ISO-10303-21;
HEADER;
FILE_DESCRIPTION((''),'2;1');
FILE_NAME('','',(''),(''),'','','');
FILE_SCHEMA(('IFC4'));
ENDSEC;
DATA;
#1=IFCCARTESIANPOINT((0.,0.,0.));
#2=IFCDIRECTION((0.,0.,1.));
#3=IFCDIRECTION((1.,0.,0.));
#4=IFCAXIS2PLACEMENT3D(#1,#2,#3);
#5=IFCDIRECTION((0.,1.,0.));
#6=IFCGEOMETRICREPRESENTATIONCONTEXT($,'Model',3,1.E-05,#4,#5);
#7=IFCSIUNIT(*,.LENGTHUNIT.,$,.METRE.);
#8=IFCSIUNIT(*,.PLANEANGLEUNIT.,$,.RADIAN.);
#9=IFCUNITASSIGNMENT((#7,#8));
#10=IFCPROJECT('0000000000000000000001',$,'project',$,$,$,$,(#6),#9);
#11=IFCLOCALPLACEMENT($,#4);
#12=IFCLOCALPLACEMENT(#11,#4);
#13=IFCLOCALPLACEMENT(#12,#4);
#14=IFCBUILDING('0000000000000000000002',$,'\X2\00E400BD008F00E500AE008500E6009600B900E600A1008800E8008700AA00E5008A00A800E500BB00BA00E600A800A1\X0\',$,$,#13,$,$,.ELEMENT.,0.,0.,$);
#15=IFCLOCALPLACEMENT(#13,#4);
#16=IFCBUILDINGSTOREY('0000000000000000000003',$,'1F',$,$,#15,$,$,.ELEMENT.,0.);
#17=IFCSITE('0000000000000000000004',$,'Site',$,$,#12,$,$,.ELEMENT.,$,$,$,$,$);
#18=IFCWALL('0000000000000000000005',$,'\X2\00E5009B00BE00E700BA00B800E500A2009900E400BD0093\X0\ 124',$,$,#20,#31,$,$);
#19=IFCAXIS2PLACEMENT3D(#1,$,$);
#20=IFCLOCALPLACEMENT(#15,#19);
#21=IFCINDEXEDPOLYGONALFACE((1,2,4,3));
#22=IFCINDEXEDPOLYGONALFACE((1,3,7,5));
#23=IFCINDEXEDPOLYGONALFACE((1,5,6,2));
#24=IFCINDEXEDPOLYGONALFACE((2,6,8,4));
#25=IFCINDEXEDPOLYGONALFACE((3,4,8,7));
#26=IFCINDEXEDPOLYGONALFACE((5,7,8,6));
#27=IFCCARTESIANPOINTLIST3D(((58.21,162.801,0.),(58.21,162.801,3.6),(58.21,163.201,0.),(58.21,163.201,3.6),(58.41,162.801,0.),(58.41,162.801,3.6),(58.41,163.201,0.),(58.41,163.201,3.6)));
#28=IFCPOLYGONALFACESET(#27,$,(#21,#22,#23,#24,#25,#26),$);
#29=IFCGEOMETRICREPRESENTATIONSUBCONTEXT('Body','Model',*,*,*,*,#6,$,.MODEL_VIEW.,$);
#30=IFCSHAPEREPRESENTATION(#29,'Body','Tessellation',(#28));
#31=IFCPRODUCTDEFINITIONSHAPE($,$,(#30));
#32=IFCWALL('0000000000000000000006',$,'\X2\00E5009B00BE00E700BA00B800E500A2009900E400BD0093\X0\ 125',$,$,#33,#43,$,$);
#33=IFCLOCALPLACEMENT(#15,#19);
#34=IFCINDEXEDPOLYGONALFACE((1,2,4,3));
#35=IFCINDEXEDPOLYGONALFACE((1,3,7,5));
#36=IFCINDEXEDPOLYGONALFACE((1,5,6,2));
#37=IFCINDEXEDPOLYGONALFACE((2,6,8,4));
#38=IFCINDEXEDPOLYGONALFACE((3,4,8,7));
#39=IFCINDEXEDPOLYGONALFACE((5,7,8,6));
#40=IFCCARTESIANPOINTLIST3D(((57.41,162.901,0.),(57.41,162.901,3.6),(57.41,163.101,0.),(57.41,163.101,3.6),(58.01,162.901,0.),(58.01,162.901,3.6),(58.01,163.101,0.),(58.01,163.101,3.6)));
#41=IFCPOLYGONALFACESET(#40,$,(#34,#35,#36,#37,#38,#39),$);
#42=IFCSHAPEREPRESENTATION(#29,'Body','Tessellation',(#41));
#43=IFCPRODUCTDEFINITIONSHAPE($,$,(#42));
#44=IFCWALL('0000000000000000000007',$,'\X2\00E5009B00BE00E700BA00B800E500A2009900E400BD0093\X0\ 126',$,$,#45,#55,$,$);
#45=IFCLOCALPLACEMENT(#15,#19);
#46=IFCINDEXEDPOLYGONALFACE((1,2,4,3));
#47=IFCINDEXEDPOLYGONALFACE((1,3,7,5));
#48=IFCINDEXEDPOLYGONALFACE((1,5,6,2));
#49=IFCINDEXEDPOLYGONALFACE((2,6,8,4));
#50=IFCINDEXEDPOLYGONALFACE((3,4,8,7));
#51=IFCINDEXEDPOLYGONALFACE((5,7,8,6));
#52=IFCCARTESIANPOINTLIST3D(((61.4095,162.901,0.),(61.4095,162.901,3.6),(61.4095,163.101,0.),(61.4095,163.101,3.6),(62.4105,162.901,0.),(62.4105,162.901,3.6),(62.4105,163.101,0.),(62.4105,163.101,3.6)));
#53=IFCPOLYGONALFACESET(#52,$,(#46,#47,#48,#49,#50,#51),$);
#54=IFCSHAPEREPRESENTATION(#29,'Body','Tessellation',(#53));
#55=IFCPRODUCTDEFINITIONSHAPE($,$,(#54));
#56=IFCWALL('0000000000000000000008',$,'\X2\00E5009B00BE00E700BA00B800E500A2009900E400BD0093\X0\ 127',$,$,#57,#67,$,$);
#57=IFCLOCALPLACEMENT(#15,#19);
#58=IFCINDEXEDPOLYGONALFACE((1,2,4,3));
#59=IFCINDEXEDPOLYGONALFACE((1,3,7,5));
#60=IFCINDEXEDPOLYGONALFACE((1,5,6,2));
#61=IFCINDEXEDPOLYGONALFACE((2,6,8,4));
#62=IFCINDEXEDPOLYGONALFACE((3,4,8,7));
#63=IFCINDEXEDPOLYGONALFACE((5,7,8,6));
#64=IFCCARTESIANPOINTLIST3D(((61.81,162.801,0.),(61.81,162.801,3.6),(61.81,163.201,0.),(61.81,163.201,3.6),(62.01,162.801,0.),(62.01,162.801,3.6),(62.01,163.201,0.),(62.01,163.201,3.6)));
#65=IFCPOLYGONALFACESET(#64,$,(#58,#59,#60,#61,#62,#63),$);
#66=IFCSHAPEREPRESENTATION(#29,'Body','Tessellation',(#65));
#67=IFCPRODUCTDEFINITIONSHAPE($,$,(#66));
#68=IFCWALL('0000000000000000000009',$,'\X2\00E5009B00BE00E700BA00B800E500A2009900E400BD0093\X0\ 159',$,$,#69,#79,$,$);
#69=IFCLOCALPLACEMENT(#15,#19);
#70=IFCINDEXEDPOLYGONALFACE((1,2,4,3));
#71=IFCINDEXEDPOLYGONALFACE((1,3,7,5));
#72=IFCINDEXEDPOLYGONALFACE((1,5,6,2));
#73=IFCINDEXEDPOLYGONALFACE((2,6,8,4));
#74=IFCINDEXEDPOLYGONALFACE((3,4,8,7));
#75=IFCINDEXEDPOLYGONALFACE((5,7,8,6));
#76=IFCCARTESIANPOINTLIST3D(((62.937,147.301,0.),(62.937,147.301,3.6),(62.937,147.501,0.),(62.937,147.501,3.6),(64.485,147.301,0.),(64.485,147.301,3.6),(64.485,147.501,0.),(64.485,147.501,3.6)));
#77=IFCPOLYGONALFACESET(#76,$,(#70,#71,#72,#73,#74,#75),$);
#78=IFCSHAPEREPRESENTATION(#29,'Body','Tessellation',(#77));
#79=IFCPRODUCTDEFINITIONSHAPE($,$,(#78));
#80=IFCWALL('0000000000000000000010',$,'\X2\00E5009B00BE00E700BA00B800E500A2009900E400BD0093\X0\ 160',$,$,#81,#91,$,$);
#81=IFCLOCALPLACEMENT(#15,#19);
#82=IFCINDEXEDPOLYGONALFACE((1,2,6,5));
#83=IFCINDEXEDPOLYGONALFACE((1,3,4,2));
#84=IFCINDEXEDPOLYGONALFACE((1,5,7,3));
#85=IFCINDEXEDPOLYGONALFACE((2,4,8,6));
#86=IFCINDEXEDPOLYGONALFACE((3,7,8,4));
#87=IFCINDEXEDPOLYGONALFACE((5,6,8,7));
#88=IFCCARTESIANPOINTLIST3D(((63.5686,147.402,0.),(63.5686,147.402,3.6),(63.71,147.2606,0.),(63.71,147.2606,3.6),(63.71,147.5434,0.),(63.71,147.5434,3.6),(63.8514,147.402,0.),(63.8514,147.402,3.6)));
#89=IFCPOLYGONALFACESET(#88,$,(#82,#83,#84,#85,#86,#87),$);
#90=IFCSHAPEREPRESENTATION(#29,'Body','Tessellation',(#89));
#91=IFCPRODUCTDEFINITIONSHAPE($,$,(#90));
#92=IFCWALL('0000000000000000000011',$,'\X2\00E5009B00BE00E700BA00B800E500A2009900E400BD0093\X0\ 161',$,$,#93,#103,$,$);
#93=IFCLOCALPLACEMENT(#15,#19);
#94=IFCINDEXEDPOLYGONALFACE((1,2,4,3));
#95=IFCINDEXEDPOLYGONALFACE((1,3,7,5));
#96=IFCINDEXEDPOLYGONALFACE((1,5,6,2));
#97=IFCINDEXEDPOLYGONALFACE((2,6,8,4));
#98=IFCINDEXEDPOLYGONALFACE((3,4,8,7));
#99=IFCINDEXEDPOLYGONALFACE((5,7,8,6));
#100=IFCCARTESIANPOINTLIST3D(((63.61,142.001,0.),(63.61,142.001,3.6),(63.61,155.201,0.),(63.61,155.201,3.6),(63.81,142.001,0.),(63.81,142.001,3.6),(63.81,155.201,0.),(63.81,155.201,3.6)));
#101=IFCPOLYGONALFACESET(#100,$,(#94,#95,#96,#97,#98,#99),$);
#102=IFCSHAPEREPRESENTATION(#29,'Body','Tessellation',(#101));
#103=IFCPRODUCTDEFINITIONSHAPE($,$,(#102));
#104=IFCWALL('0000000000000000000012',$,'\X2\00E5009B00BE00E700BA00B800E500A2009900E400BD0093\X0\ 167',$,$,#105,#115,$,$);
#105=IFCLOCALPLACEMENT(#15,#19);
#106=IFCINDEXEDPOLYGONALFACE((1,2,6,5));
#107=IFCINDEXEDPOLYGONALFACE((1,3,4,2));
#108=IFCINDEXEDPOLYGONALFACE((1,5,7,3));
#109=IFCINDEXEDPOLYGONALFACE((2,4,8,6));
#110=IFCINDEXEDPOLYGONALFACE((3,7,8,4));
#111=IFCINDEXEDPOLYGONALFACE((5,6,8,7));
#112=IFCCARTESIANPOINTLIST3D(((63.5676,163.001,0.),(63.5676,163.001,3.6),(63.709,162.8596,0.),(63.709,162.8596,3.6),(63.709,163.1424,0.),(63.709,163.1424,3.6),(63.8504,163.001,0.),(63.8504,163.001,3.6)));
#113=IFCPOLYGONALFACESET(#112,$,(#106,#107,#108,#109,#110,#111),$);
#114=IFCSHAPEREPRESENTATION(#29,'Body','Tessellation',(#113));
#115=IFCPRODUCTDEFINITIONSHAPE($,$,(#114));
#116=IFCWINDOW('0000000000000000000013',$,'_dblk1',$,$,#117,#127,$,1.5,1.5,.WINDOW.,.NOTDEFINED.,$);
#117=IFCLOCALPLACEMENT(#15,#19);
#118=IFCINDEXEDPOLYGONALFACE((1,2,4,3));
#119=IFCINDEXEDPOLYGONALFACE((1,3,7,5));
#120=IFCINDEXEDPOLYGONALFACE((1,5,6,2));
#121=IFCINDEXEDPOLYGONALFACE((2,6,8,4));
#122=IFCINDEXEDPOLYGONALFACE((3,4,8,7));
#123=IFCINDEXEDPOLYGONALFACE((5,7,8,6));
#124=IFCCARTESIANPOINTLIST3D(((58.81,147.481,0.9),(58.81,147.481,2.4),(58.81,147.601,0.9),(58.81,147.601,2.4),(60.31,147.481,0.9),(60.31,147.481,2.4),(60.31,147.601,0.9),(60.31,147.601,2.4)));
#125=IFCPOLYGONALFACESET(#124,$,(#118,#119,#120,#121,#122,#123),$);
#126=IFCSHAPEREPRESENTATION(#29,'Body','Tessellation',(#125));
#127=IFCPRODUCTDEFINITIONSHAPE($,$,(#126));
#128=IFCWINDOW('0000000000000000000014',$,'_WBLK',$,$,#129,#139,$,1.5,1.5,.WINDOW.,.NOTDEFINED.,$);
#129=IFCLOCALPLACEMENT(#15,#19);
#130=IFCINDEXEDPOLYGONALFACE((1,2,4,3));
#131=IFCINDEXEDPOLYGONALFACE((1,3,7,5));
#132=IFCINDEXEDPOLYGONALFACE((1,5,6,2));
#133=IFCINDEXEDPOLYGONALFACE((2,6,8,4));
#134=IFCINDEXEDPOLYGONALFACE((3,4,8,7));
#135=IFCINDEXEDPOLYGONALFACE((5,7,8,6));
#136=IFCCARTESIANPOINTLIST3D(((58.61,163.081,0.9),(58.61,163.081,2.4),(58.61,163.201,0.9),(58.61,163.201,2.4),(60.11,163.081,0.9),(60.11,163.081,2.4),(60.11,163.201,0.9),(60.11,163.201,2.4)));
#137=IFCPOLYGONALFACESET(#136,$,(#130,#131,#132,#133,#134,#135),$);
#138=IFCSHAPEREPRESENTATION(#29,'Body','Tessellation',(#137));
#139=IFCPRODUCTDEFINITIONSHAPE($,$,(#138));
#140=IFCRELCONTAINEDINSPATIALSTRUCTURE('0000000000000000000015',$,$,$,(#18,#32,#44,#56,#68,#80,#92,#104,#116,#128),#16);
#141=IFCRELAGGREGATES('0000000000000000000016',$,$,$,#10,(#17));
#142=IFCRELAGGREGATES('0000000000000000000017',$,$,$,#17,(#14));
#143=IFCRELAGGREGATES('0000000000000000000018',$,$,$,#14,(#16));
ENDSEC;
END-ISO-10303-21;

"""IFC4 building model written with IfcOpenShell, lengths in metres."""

from ifc_helpers import new_model, si_unit, direction, frame, frame_2d, origin_with_axes, place, context, subcontext, project, spatial, rectangle, extrude, element, save


model = new_model("IFC4")

# Units and contexts
model_context = context("Model", 3, precision=1e-05, world=origin_with_axes(), true_north=direction((0.0, 1.0, 0.0)))
body_context = subcontext(model_context, "Body", "Model", "MODEL_VIEW")
ifc_project = project(units=[si_unit("LENGTHUNIT", "METRE"), si_unit("PLANEANGLEUNIT", "RADIAN")], contexts=[model_context])

# Site, building, storey
placement = place(None, origin_with_axes())
site_placement = place(placement, origin_with_axes())
site = spatial("IfcSite", under=ifc_project, at=site_placement, Name="Site", CompositionType="ELEMENT")
building_placement = place(site_placement, origin_with_axes())
building = spatial("IfcBuilding", under=site, at=building_placement, Name="ä½\u008få®\u0085æ\u0096¹æ¡\u0088è\u0087ªå\u008a¨å»ºæ¨¡", CompositionType="ELEMENT", ElevationOfRefHeight=0.0, ElevationOfTerrain=0.0)
storey_placement = place(building_placement, origin_with_axes())
storey = spatial("IfcBuildingStorey", under=building, at=storey_placement, Name="1F", CompositionType="ELEMENT", Elevation=0.0)

# Walls
for number, where, z_axis, x_axis, name in (
    (1, (58.31, 163.001, 0.0), (0.0, 0.0, 1.0), (0.0, 1.0, 0.0), "å\u009b¾çº¸å¢\u0099ä½\u0093 124"),
):
    element("IfcWall", number, at=place(storey_placement, frame(where, z_axis=z_axis, x_axis=x_axis)), inside=storey, Name=name, context=body_context, shape_type="SweptSolid", body=[
        extrude(rectangle(XDim=0.4, YDim=0.2, at=frame_2d((0.0, 0.0), x_axis=(1.0, 0.0, 0.0))), frame((0.0, 0.0, 0.0), z_axis=(0.0, 0.0, 1.0)), (0.0, 0.0, 1.0), 3.6),
    ])
wall_1_placement = place(storey_placement, frame((57.71, 163.001, 0.0), z_axis=(0.0, 0.0, 1.0), x_axis=(1.0, 0.0, 0.0)))
element("IfcWall", 2, at=wall_1_placement, inside=storey, Name="å\u009b¾çº¸å¢\u0099ä½\u0093 125", context=body_context, shape_type="SweptSolid", body=[
    extrude(rectangle(XDim=0.6, YDim=0.2, at=frame_2d((0.0, 0.0), x_axis=(1.0, 0.0, 0.0))), frame((0.0, 0.0, 0.0), z_axis=(0.0, 0.0, 1.0)), (0.0, 0.0, 1.0), 3.6),
])
wall_2_placement = place(storey_placement, frame((61.91, 163.001, 0.0), z_axis=(0.0, 0.0, 1.0), x_axis=(1.0, 0.0, 0.0)))
element("IfcWall", 3, at=wall_2_placement, inside=storey, Name="å\u009b¾çº¸å¢\u0099ä½\u0093 126", context=body_context, shape_type="SweptSolid", body=[
    extrude(rectangle(XDim=1.001, YDim=0.2, at=frame_2d((0.0, 0.0), x_axis=(1.0, 0.0, 0.0))), frame((0.0, 0.0, 0.0), z_axis=(0.0, 0.0, 1.0)), (0.0, 0.0, 1.0), 3.6),
])
wall_3_placement = place(storey_placement, frame((61.91, 163.001, 0.0), z_axis=(0.0, 0.0, 1.0), x_axis=(0.0, 1.0, 0.0)))
element("IfcWall", 4, at=wall_3_placement, inside=storey, Name="å\u009b¾çº¸å¢\u0099ä½\u0093 127", context=body_context, shape_type="SweptSolid", body=[
    extrude(rectangle(XDim=0.4, YDim=0.2, at=frame_2d((0.0, 0.0), x_axis=(1.0, 0.0, 0.0))), frame((0.0, 0.0, 0.0), z_axis=(0.0, 0.0, 1.0)), (0.0, 0.0, 1.0), 3.6),
])
wall_4_placement = place(storey_placement, frame((63.711, 147.401, 0.0), z_axis=(0.0, 0.0, 1.0), x_axis=(1.0, 0.0, 0.0)))
element("IfcWall", 5, at=wall_4_placement, inside=storey, Name="å\u009b¾çº¸å¢\u0099ä½\u0093 159", context=body_context, shape_type="SweptSolid", body=[
    extrude(rectangle(XDim=1.548, YDim=0.2, at=frame_2d((0.0, 0.0), x_axis=(1.0, 0.0, 0.0))), frame((0.0, 0.0, 0.0), z_axis=(0.0, 0.0, 1.0)), (0.0, 0.0, 1.0), 3.6),
])
wall_5_placement = place(storey_placement, frame((63.71, 147.402, 0.0), z_axis=(0.0, 0.0, 1.0), x_axis=(0.707107, -0.707107, 0.0)))
element("IfcWall", 6, at=wall_5_placement, inside=storey, Name="å\u009b¾çº¸å¢\u0099ä½\u0093 160", context=body_context, shape_type="SweptSolid", body=[
    extrude(rectangle(XDim=0.2, YDim=0.2, at=frame_2d((0.0, 0.0), x_axis=(1.0, 0.0, 0.0))), frame((0.0, 0.0, 0.0), z_axis=(0.0, 0.0, 1.0)), (0.0, 0.0, 1.0), 3.6),
])
wall_6_placement = place(storey_placement, frame((63.71, 148.601, 0.0), z_axis=(0.0, 0.0, 1.0), x_axis=(0.0, 1.0, 0.0)))
element("IfcWall", 7, at=wall_6_placement, inside=storey, Name="å\u009b¾çº¸å¢\u0099ä½\u0093 161", context=body_context, shape_type="SweptSolid", body=[
    extrude(rectangle(XDim=13.2, YDim=0.2, at=frame_2d((0.0, 0.0), x_axis=(1.0, 0.0, 0.0))), frame((0.0, 0.0, 0.0), z_axis=(0.0, 0.0, 1.0)), (0.0, 0.0, 1.0), 3.6),
])
wall_7_placement = place(storey_placement, frame((63.709, 163.001, 0.0), z_axis=(0.0, 0.0, 1.0), x_axis=(0.707107, -0.707107, 0.0)))
element("IfcWall", 8, at=wall_7_placement, inside=storey, Name="å\u009b¾çº¸å¢\u0099ä½\u0093 167", context=body_context, shape_type="SweptSolid", body=[
    extrude(rectangle(XDim=0.2, YDim=0.2, at=frame_2d((0.0, 0.0), x_axis=(1.0, 0.0, 0.0))), frame((0.0, 0.0, 0.0), z_axis=(0.0, 0.0, 1.0)), (0.0, 0.0, 1.0), 3.6),
])

# Windows
for number, where, z_axis, x_axis, name in (
    (9, (59.56, 147.541, 0.9), (0.0, 0.0, 1.0), (1.0, 0.0, 0.0), "_dblk1"),
    (10, (59.36, 163.141, 0.9), (0.0, 0.0, 1.0), (1.0, 0.0, 0.0), "_WBLK"),
):
    element("IfcWindow", number, at=place(storey_placement, frame(where, z_axis=z_axis, x_axis=x_axis)), inside=storey, Name=name, OverallHeight=1.5, OverallWidth=1.5, PartitioningType="NOTDEFINED", PredefinedType="WINDOW", context=body_context, shape_type="SweptSolid", body=[
        extrude(rectangle(XDim=1.5, YDim=0.12, at=frame_2d((0.0, 0.0), x_axis=(1.0, 0.0, 0.0))), frame((0.0, 0.0, 0.0), z_axis=(0.0, 0.0, 1.0)), (0.0, 0.0, 1.0), 1.5),
    ])

save(model, "model.ifc")
